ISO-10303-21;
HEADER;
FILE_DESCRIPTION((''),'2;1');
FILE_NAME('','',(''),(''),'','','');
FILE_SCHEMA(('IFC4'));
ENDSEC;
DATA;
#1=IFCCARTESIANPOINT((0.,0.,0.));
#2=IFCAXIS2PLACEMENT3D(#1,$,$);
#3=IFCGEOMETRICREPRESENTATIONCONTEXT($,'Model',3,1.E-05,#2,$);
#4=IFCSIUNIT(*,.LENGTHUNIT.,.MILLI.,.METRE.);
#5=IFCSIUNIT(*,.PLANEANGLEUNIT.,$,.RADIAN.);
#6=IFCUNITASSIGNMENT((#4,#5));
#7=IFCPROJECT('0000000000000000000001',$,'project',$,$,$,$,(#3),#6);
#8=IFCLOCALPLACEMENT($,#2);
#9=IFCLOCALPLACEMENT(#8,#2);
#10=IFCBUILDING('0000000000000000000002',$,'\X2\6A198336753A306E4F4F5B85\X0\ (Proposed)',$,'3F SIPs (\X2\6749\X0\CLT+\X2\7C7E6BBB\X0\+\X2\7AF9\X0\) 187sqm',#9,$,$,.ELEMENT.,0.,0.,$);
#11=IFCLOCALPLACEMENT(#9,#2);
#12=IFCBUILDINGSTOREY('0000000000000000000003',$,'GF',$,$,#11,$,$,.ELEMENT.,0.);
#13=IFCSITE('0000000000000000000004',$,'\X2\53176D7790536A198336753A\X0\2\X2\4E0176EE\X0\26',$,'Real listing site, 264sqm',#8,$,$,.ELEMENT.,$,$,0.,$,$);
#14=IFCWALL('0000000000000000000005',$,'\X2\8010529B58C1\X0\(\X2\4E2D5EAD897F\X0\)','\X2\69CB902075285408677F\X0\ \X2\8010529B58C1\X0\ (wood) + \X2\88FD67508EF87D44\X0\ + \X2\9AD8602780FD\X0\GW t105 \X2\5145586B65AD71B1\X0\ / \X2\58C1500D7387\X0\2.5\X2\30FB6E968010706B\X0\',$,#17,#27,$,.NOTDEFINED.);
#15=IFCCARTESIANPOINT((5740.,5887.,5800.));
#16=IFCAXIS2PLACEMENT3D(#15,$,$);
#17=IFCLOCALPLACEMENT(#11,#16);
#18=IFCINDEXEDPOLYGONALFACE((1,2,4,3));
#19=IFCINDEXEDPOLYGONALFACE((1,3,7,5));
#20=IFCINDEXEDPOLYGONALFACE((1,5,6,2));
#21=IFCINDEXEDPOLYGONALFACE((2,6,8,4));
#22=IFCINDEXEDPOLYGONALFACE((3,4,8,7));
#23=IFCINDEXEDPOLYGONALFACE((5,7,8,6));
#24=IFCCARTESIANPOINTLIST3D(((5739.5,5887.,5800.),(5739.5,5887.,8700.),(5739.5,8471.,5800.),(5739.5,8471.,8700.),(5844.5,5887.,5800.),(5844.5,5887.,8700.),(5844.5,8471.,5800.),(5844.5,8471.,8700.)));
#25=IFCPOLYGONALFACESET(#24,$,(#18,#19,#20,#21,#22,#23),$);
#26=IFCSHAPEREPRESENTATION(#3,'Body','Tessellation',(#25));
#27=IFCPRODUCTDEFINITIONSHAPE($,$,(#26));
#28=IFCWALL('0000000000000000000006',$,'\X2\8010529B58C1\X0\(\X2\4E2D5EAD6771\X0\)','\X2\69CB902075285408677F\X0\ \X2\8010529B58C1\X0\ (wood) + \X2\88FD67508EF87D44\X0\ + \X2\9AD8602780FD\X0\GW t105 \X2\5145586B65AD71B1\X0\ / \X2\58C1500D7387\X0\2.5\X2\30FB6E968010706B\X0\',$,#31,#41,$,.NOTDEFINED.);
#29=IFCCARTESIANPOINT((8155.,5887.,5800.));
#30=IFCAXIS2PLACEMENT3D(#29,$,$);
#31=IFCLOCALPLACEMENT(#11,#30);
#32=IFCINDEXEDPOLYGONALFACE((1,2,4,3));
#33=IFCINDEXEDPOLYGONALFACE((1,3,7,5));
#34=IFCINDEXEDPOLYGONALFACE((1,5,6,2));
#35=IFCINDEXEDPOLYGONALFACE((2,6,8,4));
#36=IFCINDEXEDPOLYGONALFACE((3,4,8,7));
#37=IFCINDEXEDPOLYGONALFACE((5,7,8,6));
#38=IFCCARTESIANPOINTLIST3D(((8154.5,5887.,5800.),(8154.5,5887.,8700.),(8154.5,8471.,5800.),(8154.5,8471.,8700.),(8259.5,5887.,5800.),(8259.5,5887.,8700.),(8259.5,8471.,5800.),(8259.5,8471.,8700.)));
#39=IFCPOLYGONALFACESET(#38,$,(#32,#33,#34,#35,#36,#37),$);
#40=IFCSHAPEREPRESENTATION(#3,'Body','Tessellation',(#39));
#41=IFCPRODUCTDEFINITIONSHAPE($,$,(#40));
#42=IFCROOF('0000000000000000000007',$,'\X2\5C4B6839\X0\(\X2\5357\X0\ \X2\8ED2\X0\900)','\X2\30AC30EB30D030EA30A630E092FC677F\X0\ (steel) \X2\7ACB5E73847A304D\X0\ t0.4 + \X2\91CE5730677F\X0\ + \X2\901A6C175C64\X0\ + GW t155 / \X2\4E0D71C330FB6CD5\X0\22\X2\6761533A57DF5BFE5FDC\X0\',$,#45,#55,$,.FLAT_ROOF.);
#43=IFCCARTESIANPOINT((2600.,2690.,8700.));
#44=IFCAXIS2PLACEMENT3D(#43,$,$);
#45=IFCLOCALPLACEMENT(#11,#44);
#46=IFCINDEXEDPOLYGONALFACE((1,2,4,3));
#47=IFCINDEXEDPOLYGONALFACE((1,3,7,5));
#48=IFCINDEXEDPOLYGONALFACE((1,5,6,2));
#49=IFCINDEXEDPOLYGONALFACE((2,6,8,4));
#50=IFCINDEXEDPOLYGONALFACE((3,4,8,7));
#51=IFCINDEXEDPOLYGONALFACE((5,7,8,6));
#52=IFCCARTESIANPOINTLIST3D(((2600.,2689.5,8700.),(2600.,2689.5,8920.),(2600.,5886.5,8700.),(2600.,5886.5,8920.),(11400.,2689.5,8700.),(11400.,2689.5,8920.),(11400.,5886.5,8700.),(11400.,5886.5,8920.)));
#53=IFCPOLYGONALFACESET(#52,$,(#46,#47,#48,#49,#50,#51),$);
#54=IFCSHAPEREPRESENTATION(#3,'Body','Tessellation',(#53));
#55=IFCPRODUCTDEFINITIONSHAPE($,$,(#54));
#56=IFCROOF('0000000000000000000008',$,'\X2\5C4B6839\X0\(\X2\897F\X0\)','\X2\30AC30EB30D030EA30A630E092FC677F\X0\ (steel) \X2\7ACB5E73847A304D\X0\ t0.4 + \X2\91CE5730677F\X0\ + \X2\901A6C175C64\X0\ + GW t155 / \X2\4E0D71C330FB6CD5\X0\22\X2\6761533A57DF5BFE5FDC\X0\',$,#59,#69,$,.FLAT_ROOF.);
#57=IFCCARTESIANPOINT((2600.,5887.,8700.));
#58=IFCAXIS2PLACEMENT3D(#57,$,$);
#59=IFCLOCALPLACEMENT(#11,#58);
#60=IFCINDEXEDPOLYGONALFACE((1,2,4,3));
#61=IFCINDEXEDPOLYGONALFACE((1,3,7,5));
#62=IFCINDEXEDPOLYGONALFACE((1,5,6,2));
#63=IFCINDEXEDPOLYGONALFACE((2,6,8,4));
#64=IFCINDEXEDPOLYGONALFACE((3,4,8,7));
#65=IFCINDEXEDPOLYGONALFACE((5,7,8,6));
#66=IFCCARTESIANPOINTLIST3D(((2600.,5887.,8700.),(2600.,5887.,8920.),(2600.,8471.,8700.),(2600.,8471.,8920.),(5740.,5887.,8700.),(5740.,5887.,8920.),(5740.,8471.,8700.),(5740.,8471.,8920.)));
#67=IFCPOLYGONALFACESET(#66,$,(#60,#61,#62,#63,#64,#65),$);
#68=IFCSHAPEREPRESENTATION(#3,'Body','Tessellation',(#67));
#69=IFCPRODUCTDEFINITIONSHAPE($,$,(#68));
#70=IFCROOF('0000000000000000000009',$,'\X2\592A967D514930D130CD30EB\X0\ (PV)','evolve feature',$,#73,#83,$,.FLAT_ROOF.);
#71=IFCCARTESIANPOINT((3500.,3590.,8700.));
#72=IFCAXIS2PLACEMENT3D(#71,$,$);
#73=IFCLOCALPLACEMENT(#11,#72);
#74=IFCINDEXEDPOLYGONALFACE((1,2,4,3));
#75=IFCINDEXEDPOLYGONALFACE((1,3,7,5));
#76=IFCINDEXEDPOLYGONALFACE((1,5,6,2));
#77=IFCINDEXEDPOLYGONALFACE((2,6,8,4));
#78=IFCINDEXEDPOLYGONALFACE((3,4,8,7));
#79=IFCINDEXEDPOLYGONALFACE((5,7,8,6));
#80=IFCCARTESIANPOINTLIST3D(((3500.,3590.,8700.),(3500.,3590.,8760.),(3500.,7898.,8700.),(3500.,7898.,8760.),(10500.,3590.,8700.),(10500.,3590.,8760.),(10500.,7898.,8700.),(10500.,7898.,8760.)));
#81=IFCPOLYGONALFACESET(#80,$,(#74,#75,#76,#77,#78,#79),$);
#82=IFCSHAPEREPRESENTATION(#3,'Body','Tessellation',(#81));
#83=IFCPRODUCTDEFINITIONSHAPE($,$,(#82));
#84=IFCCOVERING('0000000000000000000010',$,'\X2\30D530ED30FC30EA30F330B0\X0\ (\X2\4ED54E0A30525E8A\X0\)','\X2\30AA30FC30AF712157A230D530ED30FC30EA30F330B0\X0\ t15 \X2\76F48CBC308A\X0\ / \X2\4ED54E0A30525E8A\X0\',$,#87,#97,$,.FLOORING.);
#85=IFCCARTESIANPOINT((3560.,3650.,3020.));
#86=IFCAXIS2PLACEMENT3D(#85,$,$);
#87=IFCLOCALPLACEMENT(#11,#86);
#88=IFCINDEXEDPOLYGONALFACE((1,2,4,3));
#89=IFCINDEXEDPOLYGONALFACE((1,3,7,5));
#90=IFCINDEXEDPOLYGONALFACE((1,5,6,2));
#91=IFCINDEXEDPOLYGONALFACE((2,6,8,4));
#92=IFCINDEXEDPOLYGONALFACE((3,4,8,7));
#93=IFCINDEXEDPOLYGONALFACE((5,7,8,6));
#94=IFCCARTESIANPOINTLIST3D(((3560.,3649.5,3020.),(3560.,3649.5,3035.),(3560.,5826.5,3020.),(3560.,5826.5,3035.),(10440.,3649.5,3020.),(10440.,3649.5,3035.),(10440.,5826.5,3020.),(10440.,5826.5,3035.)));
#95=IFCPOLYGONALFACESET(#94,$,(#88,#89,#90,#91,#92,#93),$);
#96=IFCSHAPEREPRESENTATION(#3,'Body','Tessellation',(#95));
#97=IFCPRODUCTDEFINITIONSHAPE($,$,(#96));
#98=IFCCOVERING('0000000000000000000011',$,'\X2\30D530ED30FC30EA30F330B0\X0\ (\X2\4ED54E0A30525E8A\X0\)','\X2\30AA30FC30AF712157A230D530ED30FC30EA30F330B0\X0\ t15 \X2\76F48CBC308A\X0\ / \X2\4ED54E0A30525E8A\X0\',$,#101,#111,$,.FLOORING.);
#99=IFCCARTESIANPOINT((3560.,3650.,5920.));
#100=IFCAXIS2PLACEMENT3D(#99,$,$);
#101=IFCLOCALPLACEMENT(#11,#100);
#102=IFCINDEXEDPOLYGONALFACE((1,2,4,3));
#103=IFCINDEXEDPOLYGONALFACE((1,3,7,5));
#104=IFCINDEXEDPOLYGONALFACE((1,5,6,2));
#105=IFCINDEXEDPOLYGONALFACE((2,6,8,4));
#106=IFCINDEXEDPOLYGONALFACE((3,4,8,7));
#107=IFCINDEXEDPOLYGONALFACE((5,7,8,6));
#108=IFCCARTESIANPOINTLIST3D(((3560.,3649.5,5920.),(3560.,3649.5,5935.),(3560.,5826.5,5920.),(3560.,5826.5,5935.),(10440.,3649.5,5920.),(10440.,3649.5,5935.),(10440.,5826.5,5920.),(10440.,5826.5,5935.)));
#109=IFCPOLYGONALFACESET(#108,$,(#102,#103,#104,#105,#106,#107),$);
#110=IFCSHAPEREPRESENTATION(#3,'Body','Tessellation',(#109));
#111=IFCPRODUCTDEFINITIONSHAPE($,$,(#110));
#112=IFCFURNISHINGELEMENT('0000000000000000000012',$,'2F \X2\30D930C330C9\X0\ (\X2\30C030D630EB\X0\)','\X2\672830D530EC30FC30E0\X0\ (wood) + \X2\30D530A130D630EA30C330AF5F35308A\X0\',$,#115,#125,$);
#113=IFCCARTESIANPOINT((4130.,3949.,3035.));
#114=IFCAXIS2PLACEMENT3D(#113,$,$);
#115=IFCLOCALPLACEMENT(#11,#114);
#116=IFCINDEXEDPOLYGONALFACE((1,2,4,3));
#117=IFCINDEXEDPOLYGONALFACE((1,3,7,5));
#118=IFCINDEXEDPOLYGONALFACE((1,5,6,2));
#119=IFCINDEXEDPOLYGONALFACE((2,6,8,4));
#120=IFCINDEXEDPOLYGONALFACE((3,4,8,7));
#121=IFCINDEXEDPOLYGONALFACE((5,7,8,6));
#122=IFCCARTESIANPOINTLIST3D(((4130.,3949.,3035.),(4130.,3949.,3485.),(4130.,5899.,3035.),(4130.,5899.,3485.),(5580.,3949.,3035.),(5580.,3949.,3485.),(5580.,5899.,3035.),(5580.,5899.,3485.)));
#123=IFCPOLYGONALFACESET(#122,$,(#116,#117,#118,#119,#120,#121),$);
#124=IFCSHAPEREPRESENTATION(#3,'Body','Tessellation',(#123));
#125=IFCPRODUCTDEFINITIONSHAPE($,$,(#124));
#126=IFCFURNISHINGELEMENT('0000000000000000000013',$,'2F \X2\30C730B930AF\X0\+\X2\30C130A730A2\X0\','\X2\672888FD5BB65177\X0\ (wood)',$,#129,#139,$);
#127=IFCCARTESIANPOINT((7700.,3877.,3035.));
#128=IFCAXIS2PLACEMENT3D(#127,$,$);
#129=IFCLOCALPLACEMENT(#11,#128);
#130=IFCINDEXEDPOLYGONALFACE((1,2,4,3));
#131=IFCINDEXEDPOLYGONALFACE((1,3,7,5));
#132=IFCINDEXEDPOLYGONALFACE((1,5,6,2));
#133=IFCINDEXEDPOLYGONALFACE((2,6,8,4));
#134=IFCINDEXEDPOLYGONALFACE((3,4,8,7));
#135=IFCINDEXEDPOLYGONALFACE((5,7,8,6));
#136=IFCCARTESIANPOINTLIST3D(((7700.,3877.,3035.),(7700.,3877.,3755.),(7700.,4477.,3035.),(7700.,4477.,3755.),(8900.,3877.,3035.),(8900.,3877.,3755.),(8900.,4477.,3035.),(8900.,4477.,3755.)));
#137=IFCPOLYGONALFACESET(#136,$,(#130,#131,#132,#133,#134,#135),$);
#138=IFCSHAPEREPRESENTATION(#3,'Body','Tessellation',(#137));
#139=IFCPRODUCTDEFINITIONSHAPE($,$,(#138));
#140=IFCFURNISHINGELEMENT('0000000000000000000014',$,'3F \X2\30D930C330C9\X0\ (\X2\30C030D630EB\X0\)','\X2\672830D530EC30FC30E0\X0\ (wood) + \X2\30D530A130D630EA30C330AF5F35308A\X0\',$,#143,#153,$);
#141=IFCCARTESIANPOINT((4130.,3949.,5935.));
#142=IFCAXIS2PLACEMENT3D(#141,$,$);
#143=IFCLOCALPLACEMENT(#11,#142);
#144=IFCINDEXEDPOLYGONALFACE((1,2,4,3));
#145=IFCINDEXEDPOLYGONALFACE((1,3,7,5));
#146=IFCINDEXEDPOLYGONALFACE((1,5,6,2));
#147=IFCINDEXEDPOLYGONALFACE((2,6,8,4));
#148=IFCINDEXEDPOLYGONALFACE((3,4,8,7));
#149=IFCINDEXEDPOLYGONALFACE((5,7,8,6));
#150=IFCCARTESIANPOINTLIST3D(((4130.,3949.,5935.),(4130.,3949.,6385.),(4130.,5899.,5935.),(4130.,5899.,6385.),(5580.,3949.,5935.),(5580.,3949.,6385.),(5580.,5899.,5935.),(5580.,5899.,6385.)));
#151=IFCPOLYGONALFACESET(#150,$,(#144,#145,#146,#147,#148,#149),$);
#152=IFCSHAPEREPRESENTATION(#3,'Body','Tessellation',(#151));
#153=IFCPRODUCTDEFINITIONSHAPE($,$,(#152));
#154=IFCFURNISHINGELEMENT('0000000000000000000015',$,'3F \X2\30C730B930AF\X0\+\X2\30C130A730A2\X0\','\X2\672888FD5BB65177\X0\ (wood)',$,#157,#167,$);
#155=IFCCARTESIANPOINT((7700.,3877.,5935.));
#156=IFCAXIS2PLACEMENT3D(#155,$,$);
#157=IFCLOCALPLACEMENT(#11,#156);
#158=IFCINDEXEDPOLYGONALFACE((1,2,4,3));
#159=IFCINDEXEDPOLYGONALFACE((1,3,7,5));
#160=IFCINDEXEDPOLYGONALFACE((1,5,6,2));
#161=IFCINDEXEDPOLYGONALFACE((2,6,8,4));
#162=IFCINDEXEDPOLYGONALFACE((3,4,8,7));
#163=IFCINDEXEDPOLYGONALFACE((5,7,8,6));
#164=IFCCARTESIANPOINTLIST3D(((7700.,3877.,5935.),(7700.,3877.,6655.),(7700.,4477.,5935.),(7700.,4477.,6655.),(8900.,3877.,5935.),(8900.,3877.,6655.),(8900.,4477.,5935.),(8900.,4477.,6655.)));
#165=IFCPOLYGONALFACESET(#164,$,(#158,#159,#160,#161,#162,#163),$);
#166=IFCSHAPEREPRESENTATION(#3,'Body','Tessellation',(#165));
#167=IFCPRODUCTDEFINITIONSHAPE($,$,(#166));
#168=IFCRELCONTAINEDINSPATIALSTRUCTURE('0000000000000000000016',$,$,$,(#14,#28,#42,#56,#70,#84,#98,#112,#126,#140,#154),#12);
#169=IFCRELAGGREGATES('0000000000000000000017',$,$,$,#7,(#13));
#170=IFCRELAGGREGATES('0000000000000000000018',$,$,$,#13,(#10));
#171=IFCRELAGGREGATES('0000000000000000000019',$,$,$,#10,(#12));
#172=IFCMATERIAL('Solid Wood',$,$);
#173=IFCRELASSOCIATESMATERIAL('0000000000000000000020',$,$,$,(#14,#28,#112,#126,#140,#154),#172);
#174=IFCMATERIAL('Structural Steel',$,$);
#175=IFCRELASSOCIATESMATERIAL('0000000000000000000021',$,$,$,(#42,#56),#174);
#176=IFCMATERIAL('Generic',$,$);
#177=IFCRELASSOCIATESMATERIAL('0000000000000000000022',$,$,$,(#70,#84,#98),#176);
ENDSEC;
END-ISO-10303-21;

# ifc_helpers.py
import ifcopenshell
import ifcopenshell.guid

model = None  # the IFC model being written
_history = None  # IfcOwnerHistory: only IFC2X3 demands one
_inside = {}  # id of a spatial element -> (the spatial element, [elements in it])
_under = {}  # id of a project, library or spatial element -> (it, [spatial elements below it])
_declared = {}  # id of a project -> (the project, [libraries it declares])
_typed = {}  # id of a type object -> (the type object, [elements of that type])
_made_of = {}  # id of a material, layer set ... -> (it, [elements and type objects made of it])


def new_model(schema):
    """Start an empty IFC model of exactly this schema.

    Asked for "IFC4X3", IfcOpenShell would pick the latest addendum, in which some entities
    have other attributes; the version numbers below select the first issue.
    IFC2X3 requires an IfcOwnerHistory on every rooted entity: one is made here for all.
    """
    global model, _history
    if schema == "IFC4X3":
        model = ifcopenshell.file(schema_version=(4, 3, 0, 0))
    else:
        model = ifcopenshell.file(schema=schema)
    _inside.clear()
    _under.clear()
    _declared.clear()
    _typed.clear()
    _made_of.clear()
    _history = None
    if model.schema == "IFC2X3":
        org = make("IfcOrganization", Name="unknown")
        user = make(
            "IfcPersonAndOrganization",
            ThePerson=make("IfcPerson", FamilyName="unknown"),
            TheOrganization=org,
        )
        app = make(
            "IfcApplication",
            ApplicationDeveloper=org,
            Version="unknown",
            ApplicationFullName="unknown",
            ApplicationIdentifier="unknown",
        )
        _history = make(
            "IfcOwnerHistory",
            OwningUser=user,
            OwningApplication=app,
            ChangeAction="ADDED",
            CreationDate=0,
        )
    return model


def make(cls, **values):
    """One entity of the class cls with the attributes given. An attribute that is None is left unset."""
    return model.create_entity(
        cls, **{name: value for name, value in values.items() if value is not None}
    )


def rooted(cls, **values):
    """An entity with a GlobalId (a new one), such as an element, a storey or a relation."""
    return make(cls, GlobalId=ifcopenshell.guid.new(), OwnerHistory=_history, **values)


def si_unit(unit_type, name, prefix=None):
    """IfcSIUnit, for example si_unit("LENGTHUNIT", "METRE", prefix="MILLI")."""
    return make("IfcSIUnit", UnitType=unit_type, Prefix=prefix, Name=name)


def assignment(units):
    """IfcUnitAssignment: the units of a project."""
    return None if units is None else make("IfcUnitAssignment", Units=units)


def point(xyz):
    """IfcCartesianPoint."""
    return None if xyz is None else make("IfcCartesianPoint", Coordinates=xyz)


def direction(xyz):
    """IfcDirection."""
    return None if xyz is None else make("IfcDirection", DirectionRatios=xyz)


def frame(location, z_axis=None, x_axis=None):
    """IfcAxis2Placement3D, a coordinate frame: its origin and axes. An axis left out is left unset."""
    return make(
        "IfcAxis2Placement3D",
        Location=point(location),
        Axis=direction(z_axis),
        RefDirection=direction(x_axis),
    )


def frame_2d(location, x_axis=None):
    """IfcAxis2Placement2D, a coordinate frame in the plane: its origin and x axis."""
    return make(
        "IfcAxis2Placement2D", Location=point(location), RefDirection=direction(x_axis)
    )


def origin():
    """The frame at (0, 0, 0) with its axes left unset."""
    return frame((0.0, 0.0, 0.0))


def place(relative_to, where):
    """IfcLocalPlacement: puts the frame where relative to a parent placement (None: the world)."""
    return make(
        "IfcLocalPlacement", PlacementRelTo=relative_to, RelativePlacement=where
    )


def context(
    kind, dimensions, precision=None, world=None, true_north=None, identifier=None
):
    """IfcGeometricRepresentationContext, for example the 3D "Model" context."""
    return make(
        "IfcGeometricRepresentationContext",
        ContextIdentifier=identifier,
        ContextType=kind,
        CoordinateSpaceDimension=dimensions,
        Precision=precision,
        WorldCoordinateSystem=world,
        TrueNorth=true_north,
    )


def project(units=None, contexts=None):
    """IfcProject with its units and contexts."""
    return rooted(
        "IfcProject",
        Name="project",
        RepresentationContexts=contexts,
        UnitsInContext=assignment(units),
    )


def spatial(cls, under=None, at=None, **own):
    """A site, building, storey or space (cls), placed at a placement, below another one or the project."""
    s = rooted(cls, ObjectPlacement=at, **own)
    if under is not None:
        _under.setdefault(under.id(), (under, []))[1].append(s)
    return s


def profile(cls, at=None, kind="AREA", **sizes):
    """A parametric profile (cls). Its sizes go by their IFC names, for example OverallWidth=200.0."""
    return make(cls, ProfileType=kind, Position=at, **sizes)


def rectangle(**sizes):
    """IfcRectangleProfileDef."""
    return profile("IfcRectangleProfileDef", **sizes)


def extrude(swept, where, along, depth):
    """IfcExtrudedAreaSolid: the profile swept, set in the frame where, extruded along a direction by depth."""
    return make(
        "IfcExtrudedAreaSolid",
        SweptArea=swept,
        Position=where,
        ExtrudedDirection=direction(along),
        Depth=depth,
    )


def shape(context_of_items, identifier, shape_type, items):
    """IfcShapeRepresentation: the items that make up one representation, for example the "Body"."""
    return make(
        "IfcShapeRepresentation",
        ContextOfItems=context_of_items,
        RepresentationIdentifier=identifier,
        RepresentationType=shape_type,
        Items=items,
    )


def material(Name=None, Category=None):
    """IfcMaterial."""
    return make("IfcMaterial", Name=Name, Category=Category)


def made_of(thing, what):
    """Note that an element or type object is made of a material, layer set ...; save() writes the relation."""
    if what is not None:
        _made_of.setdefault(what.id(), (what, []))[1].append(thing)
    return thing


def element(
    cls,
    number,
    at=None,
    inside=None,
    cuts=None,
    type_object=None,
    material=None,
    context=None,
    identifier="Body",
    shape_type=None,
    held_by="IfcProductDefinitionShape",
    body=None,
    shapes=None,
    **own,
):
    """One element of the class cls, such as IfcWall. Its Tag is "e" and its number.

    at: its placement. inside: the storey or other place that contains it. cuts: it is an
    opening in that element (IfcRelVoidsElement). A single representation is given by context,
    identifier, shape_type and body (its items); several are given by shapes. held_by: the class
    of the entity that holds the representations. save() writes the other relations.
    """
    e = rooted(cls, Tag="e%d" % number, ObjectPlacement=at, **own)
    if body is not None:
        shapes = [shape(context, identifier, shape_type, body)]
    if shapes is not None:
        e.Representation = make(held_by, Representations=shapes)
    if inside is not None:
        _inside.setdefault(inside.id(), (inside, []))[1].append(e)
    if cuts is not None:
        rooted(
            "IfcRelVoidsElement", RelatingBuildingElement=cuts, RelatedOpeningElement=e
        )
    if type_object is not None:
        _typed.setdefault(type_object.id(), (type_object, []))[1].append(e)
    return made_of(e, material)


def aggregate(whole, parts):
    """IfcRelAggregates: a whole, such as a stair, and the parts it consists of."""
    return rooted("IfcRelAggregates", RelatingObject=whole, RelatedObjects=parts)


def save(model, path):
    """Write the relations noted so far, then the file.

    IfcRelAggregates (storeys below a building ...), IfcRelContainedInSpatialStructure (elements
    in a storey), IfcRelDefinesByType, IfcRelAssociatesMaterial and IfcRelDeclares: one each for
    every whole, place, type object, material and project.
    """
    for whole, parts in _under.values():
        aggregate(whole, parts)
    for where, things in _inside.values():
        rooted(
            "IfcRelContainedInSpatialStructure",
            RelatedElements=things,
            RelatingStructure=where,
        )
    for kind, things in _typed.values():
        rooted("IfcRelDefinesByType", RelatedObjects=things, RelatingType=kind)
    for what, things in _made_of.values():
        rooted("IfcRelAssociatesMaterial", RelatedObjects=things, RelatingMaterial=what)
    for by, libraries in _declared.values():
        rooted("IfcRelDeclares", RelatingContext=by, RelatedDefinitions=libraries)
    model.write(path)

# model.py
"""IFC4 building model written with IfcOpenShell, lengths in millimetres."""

from ifc_helpers import new_model, si_unit, frame, frame_2d, origin, place, context, project, spatial, rectangle, extrude, material, element, save


model = new_model("IFC4")

# Units and contexts
model_context = context("Model", 3, precision=1e-05, world=origin())
ifc_project = project(units=[si_unit("LENGTHUNIT", "METRE", prefix="MILLI"), si_unit("PLANEANGLEUNIT", "RADIAN")], contexts=[model_context])

# Site, building, storey
site_placement = place(None, origin())
site = spatial("IfcSite", under=ifc_project, at=site_placement, Name="北海道標茶町2丁目26", ObjectType="Real listing site, 264sqm", CompositionType="ELEMENT", RefElevation=0.0)
building_placement = place(site_placement, origin())
building = spatial("IfcBuilding", under=site, at=building_placement, Name="標茶町の住宅 (Proposed)", ObjectType="3F SIPs (杉CLT+籾殻+竹) 187sqm", CompositionType="ELEMENT", ElevationOfRefHeight=0.0, ElevationOfTerrain=0.0)
storey_placement = place(building_placement, origin())
storey = spatial("IfcBuildingStorey", under=building, at=storey_placement, Name="GF", CompositionType="ELEMENT", Elevation=0.0)

# Shared definitions
ifc_material_1 = material(Name="Solid Wood")

# Walls
wall_1_placement = place(storey_placement, frame((5740.0, 5887.0, 5800.0)))
element("IfcWall", 1, at=wall_1_placement, inside=storey, material=ifc_material_1, Name="耐力壁(中庭西)", Description="構造用合板 耐力壁 (wood) + 製材軸組 + 高性能GW t105 充填断熱 / 壁倍率2.5・準耐火", PredefinedType="NOTDEFINED", context=model_context, shape_type="SweptSolid", body=[
    extrude(rectangle(XDim=105.0, YDim=2584.0, at=frame_2d((52.0, 1292.0))), frame((5740.0, 5887.0, 5800.0)), (0.0, 0.0, 1.0), 2900.0),
])
wall_2_placement = place(storey_placement, frame((8155.0, 5887.0, 5800.0)))
element("IfcWall", 2, at=wall_2_placement, inside=storey, material=ifc_material_1, Name="耐力壁(中庭東)", Description="構造用合板 耐力壁 (wood) + 製材軸組 + 高性能GW t105 充填断熱 / 壁倍率2.5・準耐火", PredefinedType="NOTDEFINED", context=model_context, shape_type="SweptSolid", body=[
    extrude(rectangle(XDim=105.0, YDim=2584.0, at=frame_2d((52.0, 1292.0))), frame((8155.0, 5887.0, 5800.0)), (0.0, 0.0, 1.0), 2900.0),
])

# Roofs
ifc_material_2 = material(Name="Structural Steel")
roof_1_placement = place(storey_placement, frame((2600.0, 2690.0, 8700.0)))
element("IfcRoof", 3, at=roof_1_placement, inside=storey, material=ifc_material_2, Name="屋根(南 軒900)", Description="ガルバリウム鋼板 (steel) 立平葺き t0.4 + 野地板 + 通気層 + GW t155 / 不燃・法22条区域対応", PredefinedType="FLAT_ROOF", context=model_context, shape_type="SweptSolid", body=[
    extrude(rectangle(XDim=8800.0, YDim=3197.0, at=frame_2d((4400.0, 1598.0))), frame((2600.0, 2690.0, 8700.0)), (0.0, 0.0, 1.0), 220.0),
])
roof_2_placement = place(storey_placement, frame((2600.0, 5887.0, 8700.0)))
element("IfcRoof", 4, at=roof_2_placement, inside=storey, material=ifc_material_2, Name="屋根(西)", Description="ガルバリウム鋼板 (steel) 立平葺き t0.4 + 野地板 + 通気層 + GW t155 / 不燃・法22条区域対応", PredefinedType="FLAT_ROOF", context=model_context, shape_type="SweptSolid", body=[
    extrude(rectangle(XDim=3140.0, YDim=2584.0, at=frame_2d((1570.0, 1292.0))), frame((2600.0, 5887.0, 8700.0)), (0.0, 0.0, 1.0), 220.0),
])
ifc_material_3 = material(Name="Generic")
roof_3_placement = place(storey_placement, frame((3500.0, 3590.0, 8700.0)))
element("IfcRoof", 5, at=roof_3_placement, inside=storey, material=ifc_material_3, Name="太陽光パネル (PV)", Description="evolve feature", PredefinedType="FLAT_ROOF", context=model_context, shape_type="SweptSolid", body=[
    extrude(rectangle(XDim=7000.0, YDim=4308.0, at=frame_2d((3500.0, 2154.0))), frame((3500.0, 3590.0, 8700.0)), (0.0, 0.0, 1.0), 60.0),
])

# Coverings
covering_1_placement = place(storey_placement, frame((3560.0, 3650.0, 3020.0)))
element("IfcCovering", 6, at=covering_1_placement, inside=storey, material=ifc_material_3, Name="フローリング (仕上げ床)", Description="オーク無垢フローリング t15 直貼り / 仕上げ床", PredefinedType="FLOORING", context=model_context, shape_type="SweptSolid", body=[
    extrude(rectangle(XDim=6880.0, YDim=2177.0, at=frame_2d((3440.0, 1088.0))), frame((3560.0, 3650.0, 3020.0)), (0.0, 0.0, 1.0), 15.0),
])
covering_2_placement = place(storey_placement, frame((3560.0, 3650.0, 5920.0)))
element("IfcCovering", 7, at=covering_2_placement, inside=storey, material=ifc_material_3, Name="フローリング (仕上げ床)", Description="オーク無垢フローリング t15 直貼り / 仕上げ床", PredefinedType="FLOORING", context=model_context, shape_type="SweptSolid", body=[
    extrude(rectangle(XDim=6880.0, YDim=2177.0, at=frame_2d((3440.0, 1088.0))), frame((3560.0, 3650.0, 5920.0)), (0.0, 0.0, 1.0), 15.0),
])

# Furnishing elements
furnishing_1_placement = place(storey_placement, frame((4130.0, 3949.0, 3035.0)))
element("IfcFurnishingElement", 8, at=furnishing_1_placement, inside=storey, material=ifc_material_1, Name="2F ベッド (ダブル)", Description="木フレーム (wood) + ファブリック張り", context=model_context, shape_type="SweptSolid", body=[
    extrude(rectangle(XDim=1450.0, YDim=1950.0, at=frame_2d((725.0, 975.0))), frame((4130.0, 3949.0, 3035.0)), (0.0, 0.0, 1.0), 450.0),
])
furnishing_2_placement = place(storey_placement, frame((7700.0, 3877.0, 3035.0)))
element("IfcFurnishingElement", 9, at=furnishing_2_placement, inside=storey, material=ifc_material_1, Name="2F デスク+チェア", Description="木製家具 (wood)", context=model_context, shape_type="SweptSolid", body=[
    extrude(rectangle(XDim=1200.0, YDim=600.0, at=frame_2d((600.0, 300.0))), frame((7700.0, 3877.0, 3035.0)), (0.0, 0.0, 1.0), 720.0),
])
furnishing_3_placement = place(storey_placement, frame((4130.0, 3949.0, 5935.0)))
element("IfcFurnishingElement", 10, at=furnishing_3_placement, inside=storey, material=ifc_material_1, Name="3F ベッド (ダブル)", Description="木フレーム (wood) + ファブリック張り", context=model_context, shape_type="SweptSolid", body=[
    extrude(rectangle(XDim=1450.0, YDim=1950.0, at=frame_2d((725.0, 975.0))), frame((4130.0, 3949.0, 5935.0)), (0.0, 0.0, 1.0), 450.0),
])
furnishing_4_placement = place(storey_placement, frame((7700.0, 3877.0, 5935.0)))
element("IfcFurnishingElement", 11, at=furnishing_4_placement, inside=storey, material=ifc_material_1, Name="3F デスク+チェア", Description="木製家具 (wood)", context=model_context, shape_type="SweptSolid", body=[
    extrude(rectangle(XDim=1200.0, YDim=600.0, at=frame_2d((600.0, 300.0))), frame((7700.0, 3877.0, 5935.0)), (0.0, 0.0, 1.0), 720.0),
])

save(model, "model.ifc")
